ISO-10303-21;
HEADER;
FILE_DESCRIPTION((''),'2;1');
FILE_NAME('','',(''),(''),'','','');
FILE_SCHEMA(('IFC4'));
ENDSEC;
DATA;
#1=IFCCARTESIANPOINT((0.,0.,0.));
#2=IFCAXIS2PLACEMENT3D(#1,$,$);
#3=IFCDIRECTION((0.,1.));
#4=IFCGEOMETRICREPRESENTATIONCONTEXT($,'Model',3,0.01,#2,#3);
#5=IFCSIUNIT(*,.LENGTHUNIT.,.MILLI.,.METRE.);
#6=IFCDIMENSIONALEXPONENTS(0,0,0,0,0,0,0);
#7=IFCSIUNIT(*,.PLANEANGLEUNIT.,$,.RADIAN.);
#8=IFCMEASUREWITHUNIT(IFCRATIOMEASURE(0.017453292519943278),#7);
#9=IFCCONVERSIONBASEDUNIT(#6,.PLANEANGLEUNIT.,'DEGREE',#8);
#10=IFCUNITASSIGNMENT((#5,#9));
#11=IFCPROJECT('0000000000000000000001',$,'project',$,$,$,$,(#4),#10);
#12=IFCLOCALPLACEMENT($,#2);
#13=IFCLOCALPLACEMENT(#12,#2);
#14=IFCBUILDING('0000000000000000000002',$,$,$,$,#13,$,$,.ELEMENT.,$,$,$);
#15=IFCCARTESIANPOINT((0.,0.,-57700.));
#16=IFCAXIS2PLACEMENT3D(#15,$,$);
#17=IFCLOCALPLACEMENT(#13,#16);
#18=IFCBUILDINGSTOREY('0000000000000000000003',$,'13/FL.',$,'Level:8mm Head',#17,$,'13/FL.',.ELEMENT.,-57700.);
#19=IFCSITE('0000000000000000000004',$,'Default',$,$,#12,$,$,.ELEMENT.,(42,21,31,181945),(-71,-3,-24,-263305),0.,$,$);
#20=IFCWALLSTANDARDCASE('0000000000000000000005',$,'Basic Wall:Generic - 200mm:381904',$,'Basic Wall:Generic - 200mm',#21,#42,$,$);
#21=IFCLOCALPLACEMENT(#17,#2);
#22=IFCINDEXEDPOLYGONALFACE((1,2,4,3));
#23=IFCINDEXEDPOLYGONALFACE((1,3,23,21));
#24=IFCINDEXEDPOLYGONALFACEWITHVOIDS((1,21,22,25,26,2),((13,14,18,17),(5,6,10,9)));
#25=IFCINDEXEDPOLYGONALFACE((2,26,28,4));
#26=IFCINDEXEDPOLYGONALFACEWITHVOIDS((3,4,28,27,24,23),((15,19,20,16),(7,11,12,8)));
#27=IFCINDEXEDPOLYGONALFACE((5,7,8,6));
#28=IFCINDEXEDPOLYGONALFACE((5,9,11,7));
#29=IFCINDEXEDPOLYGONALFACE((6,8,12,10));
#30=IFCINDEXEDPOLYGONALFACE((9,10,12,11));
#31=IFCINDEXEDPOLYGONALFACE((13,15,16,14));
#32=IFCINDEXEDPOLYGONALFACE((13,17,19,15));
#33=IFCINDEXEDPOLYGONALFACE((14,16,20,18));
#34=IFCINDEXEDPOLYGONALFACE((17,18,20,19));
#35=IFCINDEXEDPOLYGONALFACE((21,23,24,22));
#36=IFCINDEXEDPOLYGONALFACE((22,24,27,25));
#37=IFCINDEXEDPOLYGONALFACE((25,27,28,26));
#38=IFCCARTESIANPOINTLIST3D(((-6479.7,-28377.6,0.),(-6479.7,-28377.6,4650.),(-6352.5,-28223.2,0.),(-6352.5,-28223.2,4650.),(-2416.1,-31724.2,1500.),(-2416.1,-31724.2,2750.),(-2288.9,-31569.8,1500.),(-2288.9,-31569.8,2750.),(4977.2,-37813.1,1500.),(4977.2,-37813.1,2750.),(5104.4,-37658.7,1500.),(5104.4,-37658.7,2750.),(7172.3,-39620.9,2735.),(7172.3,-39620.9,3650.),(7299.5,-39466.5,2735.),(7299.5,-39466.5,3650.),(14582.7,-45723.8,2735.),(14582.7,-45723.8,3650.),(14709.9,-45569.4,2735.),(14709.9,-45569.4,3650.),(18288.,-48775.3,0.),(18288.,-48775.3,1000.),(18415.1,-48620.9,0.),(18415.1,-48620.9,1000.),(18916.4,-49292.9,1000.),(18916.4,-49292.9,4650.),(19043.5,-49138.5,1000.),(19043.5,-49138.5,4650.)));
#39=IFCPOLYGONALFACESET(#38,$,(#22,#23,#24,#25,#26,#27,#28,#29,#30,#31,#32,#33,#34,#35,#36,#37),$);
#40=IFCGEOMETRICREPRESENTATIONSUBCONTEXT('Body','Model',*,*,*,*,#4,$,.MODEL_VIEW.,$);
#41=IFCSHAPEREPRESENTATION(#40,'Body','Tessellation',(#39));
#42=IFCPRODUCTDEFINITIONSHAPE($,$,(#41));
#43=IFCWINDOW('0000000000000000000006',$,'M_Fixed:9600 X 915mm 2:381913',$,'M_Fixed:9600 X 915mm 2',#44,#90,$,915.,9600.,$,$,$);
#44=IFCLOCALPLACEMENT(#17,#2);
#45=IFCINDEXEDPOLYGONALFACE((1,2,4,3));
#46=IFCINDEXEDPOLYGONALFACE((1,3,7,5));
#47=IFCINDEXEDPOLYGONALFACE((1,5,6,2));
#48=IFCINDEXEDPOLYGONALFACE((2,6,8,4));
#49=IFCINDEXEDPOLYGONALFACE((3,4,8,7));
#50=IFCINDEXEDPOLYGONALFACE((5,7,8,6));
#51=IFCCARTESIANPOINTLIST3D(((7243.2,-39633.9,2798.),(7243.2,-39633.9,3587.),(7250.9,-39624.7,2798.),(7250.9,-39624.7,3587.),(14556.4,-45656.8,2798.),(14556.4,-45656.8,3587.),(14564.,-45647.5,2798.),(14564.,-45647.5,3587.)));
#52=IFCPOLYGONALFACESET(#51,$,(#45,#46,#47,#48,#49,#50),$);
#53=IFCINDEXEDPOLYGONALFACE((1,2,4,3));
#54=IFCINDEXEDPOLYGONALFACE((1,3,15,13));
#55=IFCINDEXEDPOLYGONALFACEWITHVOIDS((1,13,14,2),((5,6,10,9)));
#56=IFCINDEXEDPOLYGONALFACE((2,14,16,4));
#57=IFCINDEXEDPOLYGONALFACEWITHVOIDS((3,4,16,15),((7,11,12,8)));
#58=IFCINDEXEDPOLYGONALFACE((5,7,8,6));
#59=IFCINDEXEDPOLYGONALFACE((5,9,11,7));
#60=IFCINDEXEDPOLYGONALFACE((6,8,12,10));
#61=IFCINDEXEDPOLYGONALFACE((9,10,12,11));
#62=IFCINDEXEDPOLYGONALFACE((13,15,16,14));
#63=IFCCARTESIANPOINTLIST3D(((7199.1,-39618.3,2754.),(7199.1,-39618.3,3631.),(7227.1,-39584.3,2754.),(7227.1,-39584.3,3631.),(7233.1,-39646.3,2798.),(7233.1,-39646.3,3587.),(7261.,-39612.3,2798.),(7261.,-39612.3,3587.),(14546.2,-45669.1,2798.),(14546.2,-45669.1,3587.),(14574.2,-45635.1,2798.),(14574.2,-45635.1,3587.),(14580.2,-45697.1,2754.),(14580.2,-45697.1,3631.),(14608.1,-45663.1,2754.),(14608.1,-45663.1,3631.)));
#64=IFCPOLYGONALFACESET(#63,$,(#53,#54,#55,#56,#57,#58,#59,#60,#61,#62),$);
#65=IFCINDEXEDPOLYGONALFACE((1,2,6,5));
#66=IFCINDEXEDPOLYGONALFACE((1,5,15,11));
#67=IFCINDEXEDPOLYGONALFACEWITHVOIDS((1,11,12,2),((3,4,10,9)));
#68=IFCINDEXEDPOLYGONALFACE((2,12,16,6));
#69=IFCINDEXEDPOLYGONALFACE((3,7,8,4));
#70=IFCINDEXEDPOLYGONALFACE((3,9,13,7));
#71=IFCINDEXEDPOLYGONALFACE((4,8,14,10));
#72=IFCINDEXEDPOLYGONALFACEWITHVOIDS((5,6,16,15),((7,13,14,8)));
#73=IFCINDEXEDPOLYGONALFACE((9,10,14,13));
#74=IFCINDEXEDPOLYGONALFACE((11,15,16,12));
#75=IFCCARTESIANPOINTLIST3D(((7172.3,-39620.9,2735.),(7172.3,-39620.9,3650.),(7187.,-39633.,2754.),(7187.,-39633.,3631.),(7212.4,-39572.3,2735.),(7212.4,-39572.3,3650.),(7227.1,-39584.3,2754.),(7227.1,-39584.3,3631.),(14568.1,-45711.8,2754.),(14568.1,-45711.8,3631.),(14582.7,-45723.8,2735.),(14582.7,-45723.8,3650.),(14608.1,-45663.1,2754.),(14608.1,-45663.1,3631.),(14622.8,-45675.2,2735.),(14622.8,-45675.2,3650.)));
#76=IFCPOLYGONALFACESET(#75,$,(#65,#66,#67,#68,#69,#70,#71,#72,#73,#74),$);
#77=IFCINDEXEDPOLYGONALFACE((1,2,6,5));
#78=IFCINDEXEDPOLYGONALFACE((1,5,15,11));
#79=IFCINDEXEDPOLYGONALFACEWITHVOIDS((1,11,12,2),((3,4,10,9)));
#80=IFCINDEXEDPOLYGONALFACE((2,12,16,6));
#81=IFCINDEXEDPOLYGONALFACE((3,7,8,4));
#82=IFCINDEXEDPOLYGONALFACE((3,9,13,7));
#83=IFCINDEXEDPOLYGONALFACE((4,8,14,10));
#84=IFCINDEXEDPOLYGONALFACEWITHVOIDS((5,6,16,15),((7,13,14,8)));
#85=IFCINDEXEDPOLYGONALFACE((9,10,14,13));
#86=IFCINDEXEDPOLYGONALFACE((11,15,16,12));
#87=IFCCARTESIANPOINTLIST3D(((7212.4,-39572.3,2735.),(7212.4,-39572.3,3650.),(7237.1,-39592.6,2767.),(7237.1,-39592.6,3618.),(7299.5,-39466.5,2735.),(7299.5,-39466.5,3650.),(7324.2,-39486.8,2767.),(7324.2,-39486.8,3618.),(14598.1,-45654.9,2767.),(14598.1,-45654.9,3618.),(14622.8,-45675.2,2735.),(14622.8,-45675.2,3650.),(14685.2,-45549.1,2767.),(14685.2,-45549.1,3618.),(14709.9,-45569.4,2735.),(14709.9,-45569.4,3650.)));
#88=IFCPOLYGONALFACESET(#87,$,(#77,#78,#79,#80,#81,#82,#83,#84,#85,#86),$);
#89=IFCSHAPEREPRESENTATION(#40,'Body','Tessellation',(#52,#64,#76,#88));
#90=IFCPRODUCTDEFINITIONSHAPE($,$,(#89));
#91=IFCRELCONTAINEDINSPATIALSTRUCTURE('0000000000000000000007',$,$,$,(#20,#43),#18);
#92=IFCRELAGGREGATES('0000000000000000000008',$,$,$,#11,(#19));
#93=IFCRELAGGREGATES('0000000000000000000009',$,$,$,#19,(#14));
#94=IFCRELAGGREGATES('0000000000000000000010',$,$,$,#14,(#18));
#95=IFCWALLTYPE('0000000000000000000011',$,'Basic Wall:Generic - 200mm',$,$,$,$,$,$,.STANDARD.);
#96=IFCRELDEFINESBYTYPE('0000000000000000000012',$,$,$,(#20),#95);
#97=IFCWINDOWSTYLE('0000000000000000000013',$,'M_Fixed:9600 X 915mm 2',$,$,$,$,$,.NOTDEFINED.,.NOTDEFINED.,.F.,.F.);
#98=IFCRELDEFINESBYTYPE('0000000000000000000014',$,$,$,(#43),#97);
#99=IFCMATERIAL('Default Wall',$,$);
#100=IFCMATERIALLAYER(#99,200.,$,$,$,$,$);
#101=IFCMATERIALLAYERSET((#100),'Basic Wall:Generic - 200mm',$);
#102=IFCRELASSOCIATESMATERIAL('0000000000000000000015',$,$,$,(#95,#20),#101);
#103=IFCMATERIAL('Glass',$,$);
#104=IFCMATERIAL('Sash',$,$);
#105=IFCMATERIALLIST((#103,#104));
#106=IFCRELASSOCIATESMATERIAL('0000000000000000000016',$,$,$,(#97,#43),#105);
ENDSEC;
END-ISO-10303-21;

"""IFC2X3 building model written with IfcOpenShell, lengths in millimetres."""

from ifc_helpers import new_model, entity, si_unit, converted_unit, direction, frame, frame_2d, origin, place, context, subcontext, project, spatial, polyline, rectangle, outline, extrude, source, transform, mapped, material, material_list, layer, layer_set, layer_usage, type_object, type_shapes, element, fill, save


model = new_model("IFC2X3")

# Units and contexts
model_context = context("Model", 3, precision=0.01, world=origin(), true_north=direction((0.0, 1.0)))
body_context = subcontext(model_context, "Body", "Model", "MODEL_VIEW")
ifc_project = project(units=[si_unit("LENGTHUNIT", "METRE", prefix="MILLI"), converted_unit("PLANEANGLEUNIT", "DEGREE", entity("IfcRatioMeasure", 0.017453292519943278), si_unit("PLANEANGLEUNIT", "RADIAN"), dimensions=[0, 0, 0, 0, 0, 0, 0])], contexts=[model_context])

# Site, building, storey
site_placement = place(None, origin())
site = spatial("IfcSite", under=ifc_project, at=site_placement, Name="Default", CompositionType="ELEMENT", RefLatitude=(42, 21, 31, 181945), RefLongitude=(-71, -3, -24, -263305), RefElevation=0.0)
building_placement = place(site_placement, origin())
building = spatial("IfcBuilding", under=site, at=building_placement, CompositionType="ELEMENT")
storey_placement = place(building_placement, frame((0.0, 0.0, -57700.0)))
storey = spatial("IfcBuildingStorey", under=building, at=storey_placement, Name="13/FL.", ObjectType="Level:8mm Head", LongName="13/FL.", CompositionType="ELEMENT", Elevation=-57700.0)

# Shared definitions
ifc_material_1 = material(Name="Default Wall")
ifc_layer = layer(ifc_material_1, 200.0)
ifc_layer_set = layer_set([ifc_layer], Name="Basic Wall:Generic - 200mm")
ifc_layer_usage = layer_usage(ifc_layer_set, "AXIS2", "NEGATIVE", 100.0)
wall_type = type_object("IfcWallType", Name="Basic Wall:Generic - 200mm", PredefinedType="STANDARD", material=ifc_layer_set)

# Shared definitions
ifc_material_2 = material(Name="Glass")
ifc_material_3 = material(Name="Sash")
ifc_material_list = material_list([ifc_material_2, ifc_material_3])

# Wall, openings, window
wall_1_placement = place(storey_placement, frame((-6416.1, -28300.4, 0.0), z_axis=(0.0, 0.0, 1.0), x_axis=(0.771917, -0.635723, 0.0)))
wall_1 = element("IfcWallStandardCase", 1, at=wall_1_placement, inside=storey, type_object=wall_type, material=ifc_layer_usage, Name="Basic Wall:Generic - 200mm:381904", ObjectType="Basic Wall:Generic - 200mm", context=body_context, shape_type="SweptSolid", body=[
    extrude(rectangle(XDim=32900.0, YDim=200.0, at=frame_2d((16450.0, 0.0), x_axis=(-1.0, 0.0))), origin(), (0.0, 0.0, 1.0), 4650.0),
])
opening_1_placement = place(wall_1_placement, origin())
element("IfcOpeningElement", 2, at=opening_1_placement, cuts=wall_1, ObjectType="Opening", context=body_context, shape_type="SweptSolid", body=[
    extrude(rectangle(XDim=1250.0, YDim=9577.8, at=frame_2d((0.0, 0.0), x_axis=(1.0, 0.0))), frame((10053.2, -100.0, 2125.0), z_axis=(0.0, 1.0, 0.0), x_axis=(0.0, 0.0, -1.0)), (0.0, 0.0, 1.0), 200.0),
])
opening_2_placement = place(wall_1_placement, frame((-13038.5, 25924.4, 0.0), z_axis=(0.0, 0.0, 1.0), x_axis=(0.771917, 0.635723, 0.0)))
element("IfcOpeningElement", 3, at=opening_2_placement, cuts=wall_1, ObjectType="Opening", context=body_context, shape_type="SweptSolid", body=[
    extrude(rectangle(XDim=1000.0, YDim=1010.1, at=frame_2d((0.0, 0.0), x_axis=(1.0, 0.0))), frame((18669.7, -49106.2, 500.0), z_axis=(0.635723, 0.771917, 0.0), x_axis=(0.0, 0.0, -1.0)), (0.0, 0.0, 1.0), 1012.7),
])
opening_3_placement = place(wall_1_placement, frame((27285.9, 100.0, 2735.0)))
opening_3 = element("IfcOpeningElement", 4, at=opening_3_placement, cuts=wall_1, ObjectType="Opening", context=body_context, shape_type="SweptSolid", body=[
    extrude(rectangle(XDim=915.0, YDim=9600.0, at=frame_2d((457.5, 4800.0), x_axis=(1.0, 0.0))), frame((0.0, 0.0, 0.0), z_axis=(0.0, -1.0, 0.0), x_axis=(0.0, 0.0, 1.0)), (0.0, 0.0, 1.0), 200.0),
])
window_style_1 = type_object("IfcWindowStyle", Name="M_Fixed:9600 X 915mm 2", ConstructionType="NOTDEFINED", OperationType="NOTDEFINED", ParameterTakesPrecedence=False, Sizeable=False, material=ifc_material_list)
shared_shape_1 = source(origin(), body_context, "Body", "SweptSolid", [
    extrude(rectangle(XDim=12.0, YDim=9474.0, at=frame_2d((0.0, 0.0), x_axis=(1.0, 0.0))), frame((4800.0, 159.0, 63.0), z_axis=(0.0, 0.0, 1.0), x_axis=(0.0, -1.0, 0.0)), (0.0, 0.0, 1.0), 789.0),
    extrude(outline(polyline([(-4781.0, -438.5), (4781.0, -438.5), (4781.0, 438.5), (-4781.0, 438.5), (-4781.0, -438.5)]), holes=[polyline([(-4737.0, -394.5), (-4737.0, 394.5), (4737.0, 394.5), (4737.0, -394.5), (-4737.0, -394.5)])]), frame((4800.0, 137.0, 457.5), z_axis=(0.0, 1.0, 0.0), x_axis=(1.0, 0.0, 0.0)), (0.0, 0.0, 1.0), 44.0),
    extrude(outline(polyline([(-4800.0, -457.5), (4800.0, -457.5), (4800.0, 457.5), (-4800.0, 457.5), (-4800.0, -457.5)]), holes=[polyline([(-4781.0, -438.5), (-4781.0, 438.5), (4781.0, 438.5), (4781.0, -438.5), (-4781.0, -438.5)])]), frame((4800.0, 137.0, 457.5), z_axis=(0.0, 1.0, 0.0), x_axis=(1.0, 0.0, 0.0)), (0.0, 0.0, 1.0), 63.0),
    extrude(outline(polyline([(-4800.0, -457.5), (4800.0, -457.5), (4800.0, 457.5), (-4800.0, 457.5), (-4800.0, -457.5)]), holes=[polyline([(-4768.0, -425.5), (-4768.0, 425.5), (4768.0, 425.5), (4768.0, -425.5), (-4768.0, -425.5)])]), frame((4800.0, 0.0, 457.5), z_axis=(0.0, 1.0, 0.0), x_axis=(1.0, 0.0, 0.0)), (0.0, 0.0, 1.0), 137.0),
])
type_shapes(window_style_1, [shared_shape_1])
window_1_placement = place(opening_3_placement, frame((0.0, 0.0, 0.0), z_axis=(0.0, 0.0, 1.0), x_axis=(-1.0, 0.0, 0.0)))
window_1 = element("IfcWindow", 5, at=window_1_placement, inside=storey, type_object=window_style_1, material=ifc_material_list, Name="M_Fixed:9600 X 915mm 2:381913", ObjectType="M_Fixed:9600 X 915mm 2", OverallHeight=915.0, OverallWidth=9600.0, context=body_context, shape_type="MappedRepresentation", body=[
    mapped(shared_shape_1, transform((0.0, 0.0, 0.0), scale=1.0)),
])
fill(opening_3, window_1)

save(model, "model.ifc")
